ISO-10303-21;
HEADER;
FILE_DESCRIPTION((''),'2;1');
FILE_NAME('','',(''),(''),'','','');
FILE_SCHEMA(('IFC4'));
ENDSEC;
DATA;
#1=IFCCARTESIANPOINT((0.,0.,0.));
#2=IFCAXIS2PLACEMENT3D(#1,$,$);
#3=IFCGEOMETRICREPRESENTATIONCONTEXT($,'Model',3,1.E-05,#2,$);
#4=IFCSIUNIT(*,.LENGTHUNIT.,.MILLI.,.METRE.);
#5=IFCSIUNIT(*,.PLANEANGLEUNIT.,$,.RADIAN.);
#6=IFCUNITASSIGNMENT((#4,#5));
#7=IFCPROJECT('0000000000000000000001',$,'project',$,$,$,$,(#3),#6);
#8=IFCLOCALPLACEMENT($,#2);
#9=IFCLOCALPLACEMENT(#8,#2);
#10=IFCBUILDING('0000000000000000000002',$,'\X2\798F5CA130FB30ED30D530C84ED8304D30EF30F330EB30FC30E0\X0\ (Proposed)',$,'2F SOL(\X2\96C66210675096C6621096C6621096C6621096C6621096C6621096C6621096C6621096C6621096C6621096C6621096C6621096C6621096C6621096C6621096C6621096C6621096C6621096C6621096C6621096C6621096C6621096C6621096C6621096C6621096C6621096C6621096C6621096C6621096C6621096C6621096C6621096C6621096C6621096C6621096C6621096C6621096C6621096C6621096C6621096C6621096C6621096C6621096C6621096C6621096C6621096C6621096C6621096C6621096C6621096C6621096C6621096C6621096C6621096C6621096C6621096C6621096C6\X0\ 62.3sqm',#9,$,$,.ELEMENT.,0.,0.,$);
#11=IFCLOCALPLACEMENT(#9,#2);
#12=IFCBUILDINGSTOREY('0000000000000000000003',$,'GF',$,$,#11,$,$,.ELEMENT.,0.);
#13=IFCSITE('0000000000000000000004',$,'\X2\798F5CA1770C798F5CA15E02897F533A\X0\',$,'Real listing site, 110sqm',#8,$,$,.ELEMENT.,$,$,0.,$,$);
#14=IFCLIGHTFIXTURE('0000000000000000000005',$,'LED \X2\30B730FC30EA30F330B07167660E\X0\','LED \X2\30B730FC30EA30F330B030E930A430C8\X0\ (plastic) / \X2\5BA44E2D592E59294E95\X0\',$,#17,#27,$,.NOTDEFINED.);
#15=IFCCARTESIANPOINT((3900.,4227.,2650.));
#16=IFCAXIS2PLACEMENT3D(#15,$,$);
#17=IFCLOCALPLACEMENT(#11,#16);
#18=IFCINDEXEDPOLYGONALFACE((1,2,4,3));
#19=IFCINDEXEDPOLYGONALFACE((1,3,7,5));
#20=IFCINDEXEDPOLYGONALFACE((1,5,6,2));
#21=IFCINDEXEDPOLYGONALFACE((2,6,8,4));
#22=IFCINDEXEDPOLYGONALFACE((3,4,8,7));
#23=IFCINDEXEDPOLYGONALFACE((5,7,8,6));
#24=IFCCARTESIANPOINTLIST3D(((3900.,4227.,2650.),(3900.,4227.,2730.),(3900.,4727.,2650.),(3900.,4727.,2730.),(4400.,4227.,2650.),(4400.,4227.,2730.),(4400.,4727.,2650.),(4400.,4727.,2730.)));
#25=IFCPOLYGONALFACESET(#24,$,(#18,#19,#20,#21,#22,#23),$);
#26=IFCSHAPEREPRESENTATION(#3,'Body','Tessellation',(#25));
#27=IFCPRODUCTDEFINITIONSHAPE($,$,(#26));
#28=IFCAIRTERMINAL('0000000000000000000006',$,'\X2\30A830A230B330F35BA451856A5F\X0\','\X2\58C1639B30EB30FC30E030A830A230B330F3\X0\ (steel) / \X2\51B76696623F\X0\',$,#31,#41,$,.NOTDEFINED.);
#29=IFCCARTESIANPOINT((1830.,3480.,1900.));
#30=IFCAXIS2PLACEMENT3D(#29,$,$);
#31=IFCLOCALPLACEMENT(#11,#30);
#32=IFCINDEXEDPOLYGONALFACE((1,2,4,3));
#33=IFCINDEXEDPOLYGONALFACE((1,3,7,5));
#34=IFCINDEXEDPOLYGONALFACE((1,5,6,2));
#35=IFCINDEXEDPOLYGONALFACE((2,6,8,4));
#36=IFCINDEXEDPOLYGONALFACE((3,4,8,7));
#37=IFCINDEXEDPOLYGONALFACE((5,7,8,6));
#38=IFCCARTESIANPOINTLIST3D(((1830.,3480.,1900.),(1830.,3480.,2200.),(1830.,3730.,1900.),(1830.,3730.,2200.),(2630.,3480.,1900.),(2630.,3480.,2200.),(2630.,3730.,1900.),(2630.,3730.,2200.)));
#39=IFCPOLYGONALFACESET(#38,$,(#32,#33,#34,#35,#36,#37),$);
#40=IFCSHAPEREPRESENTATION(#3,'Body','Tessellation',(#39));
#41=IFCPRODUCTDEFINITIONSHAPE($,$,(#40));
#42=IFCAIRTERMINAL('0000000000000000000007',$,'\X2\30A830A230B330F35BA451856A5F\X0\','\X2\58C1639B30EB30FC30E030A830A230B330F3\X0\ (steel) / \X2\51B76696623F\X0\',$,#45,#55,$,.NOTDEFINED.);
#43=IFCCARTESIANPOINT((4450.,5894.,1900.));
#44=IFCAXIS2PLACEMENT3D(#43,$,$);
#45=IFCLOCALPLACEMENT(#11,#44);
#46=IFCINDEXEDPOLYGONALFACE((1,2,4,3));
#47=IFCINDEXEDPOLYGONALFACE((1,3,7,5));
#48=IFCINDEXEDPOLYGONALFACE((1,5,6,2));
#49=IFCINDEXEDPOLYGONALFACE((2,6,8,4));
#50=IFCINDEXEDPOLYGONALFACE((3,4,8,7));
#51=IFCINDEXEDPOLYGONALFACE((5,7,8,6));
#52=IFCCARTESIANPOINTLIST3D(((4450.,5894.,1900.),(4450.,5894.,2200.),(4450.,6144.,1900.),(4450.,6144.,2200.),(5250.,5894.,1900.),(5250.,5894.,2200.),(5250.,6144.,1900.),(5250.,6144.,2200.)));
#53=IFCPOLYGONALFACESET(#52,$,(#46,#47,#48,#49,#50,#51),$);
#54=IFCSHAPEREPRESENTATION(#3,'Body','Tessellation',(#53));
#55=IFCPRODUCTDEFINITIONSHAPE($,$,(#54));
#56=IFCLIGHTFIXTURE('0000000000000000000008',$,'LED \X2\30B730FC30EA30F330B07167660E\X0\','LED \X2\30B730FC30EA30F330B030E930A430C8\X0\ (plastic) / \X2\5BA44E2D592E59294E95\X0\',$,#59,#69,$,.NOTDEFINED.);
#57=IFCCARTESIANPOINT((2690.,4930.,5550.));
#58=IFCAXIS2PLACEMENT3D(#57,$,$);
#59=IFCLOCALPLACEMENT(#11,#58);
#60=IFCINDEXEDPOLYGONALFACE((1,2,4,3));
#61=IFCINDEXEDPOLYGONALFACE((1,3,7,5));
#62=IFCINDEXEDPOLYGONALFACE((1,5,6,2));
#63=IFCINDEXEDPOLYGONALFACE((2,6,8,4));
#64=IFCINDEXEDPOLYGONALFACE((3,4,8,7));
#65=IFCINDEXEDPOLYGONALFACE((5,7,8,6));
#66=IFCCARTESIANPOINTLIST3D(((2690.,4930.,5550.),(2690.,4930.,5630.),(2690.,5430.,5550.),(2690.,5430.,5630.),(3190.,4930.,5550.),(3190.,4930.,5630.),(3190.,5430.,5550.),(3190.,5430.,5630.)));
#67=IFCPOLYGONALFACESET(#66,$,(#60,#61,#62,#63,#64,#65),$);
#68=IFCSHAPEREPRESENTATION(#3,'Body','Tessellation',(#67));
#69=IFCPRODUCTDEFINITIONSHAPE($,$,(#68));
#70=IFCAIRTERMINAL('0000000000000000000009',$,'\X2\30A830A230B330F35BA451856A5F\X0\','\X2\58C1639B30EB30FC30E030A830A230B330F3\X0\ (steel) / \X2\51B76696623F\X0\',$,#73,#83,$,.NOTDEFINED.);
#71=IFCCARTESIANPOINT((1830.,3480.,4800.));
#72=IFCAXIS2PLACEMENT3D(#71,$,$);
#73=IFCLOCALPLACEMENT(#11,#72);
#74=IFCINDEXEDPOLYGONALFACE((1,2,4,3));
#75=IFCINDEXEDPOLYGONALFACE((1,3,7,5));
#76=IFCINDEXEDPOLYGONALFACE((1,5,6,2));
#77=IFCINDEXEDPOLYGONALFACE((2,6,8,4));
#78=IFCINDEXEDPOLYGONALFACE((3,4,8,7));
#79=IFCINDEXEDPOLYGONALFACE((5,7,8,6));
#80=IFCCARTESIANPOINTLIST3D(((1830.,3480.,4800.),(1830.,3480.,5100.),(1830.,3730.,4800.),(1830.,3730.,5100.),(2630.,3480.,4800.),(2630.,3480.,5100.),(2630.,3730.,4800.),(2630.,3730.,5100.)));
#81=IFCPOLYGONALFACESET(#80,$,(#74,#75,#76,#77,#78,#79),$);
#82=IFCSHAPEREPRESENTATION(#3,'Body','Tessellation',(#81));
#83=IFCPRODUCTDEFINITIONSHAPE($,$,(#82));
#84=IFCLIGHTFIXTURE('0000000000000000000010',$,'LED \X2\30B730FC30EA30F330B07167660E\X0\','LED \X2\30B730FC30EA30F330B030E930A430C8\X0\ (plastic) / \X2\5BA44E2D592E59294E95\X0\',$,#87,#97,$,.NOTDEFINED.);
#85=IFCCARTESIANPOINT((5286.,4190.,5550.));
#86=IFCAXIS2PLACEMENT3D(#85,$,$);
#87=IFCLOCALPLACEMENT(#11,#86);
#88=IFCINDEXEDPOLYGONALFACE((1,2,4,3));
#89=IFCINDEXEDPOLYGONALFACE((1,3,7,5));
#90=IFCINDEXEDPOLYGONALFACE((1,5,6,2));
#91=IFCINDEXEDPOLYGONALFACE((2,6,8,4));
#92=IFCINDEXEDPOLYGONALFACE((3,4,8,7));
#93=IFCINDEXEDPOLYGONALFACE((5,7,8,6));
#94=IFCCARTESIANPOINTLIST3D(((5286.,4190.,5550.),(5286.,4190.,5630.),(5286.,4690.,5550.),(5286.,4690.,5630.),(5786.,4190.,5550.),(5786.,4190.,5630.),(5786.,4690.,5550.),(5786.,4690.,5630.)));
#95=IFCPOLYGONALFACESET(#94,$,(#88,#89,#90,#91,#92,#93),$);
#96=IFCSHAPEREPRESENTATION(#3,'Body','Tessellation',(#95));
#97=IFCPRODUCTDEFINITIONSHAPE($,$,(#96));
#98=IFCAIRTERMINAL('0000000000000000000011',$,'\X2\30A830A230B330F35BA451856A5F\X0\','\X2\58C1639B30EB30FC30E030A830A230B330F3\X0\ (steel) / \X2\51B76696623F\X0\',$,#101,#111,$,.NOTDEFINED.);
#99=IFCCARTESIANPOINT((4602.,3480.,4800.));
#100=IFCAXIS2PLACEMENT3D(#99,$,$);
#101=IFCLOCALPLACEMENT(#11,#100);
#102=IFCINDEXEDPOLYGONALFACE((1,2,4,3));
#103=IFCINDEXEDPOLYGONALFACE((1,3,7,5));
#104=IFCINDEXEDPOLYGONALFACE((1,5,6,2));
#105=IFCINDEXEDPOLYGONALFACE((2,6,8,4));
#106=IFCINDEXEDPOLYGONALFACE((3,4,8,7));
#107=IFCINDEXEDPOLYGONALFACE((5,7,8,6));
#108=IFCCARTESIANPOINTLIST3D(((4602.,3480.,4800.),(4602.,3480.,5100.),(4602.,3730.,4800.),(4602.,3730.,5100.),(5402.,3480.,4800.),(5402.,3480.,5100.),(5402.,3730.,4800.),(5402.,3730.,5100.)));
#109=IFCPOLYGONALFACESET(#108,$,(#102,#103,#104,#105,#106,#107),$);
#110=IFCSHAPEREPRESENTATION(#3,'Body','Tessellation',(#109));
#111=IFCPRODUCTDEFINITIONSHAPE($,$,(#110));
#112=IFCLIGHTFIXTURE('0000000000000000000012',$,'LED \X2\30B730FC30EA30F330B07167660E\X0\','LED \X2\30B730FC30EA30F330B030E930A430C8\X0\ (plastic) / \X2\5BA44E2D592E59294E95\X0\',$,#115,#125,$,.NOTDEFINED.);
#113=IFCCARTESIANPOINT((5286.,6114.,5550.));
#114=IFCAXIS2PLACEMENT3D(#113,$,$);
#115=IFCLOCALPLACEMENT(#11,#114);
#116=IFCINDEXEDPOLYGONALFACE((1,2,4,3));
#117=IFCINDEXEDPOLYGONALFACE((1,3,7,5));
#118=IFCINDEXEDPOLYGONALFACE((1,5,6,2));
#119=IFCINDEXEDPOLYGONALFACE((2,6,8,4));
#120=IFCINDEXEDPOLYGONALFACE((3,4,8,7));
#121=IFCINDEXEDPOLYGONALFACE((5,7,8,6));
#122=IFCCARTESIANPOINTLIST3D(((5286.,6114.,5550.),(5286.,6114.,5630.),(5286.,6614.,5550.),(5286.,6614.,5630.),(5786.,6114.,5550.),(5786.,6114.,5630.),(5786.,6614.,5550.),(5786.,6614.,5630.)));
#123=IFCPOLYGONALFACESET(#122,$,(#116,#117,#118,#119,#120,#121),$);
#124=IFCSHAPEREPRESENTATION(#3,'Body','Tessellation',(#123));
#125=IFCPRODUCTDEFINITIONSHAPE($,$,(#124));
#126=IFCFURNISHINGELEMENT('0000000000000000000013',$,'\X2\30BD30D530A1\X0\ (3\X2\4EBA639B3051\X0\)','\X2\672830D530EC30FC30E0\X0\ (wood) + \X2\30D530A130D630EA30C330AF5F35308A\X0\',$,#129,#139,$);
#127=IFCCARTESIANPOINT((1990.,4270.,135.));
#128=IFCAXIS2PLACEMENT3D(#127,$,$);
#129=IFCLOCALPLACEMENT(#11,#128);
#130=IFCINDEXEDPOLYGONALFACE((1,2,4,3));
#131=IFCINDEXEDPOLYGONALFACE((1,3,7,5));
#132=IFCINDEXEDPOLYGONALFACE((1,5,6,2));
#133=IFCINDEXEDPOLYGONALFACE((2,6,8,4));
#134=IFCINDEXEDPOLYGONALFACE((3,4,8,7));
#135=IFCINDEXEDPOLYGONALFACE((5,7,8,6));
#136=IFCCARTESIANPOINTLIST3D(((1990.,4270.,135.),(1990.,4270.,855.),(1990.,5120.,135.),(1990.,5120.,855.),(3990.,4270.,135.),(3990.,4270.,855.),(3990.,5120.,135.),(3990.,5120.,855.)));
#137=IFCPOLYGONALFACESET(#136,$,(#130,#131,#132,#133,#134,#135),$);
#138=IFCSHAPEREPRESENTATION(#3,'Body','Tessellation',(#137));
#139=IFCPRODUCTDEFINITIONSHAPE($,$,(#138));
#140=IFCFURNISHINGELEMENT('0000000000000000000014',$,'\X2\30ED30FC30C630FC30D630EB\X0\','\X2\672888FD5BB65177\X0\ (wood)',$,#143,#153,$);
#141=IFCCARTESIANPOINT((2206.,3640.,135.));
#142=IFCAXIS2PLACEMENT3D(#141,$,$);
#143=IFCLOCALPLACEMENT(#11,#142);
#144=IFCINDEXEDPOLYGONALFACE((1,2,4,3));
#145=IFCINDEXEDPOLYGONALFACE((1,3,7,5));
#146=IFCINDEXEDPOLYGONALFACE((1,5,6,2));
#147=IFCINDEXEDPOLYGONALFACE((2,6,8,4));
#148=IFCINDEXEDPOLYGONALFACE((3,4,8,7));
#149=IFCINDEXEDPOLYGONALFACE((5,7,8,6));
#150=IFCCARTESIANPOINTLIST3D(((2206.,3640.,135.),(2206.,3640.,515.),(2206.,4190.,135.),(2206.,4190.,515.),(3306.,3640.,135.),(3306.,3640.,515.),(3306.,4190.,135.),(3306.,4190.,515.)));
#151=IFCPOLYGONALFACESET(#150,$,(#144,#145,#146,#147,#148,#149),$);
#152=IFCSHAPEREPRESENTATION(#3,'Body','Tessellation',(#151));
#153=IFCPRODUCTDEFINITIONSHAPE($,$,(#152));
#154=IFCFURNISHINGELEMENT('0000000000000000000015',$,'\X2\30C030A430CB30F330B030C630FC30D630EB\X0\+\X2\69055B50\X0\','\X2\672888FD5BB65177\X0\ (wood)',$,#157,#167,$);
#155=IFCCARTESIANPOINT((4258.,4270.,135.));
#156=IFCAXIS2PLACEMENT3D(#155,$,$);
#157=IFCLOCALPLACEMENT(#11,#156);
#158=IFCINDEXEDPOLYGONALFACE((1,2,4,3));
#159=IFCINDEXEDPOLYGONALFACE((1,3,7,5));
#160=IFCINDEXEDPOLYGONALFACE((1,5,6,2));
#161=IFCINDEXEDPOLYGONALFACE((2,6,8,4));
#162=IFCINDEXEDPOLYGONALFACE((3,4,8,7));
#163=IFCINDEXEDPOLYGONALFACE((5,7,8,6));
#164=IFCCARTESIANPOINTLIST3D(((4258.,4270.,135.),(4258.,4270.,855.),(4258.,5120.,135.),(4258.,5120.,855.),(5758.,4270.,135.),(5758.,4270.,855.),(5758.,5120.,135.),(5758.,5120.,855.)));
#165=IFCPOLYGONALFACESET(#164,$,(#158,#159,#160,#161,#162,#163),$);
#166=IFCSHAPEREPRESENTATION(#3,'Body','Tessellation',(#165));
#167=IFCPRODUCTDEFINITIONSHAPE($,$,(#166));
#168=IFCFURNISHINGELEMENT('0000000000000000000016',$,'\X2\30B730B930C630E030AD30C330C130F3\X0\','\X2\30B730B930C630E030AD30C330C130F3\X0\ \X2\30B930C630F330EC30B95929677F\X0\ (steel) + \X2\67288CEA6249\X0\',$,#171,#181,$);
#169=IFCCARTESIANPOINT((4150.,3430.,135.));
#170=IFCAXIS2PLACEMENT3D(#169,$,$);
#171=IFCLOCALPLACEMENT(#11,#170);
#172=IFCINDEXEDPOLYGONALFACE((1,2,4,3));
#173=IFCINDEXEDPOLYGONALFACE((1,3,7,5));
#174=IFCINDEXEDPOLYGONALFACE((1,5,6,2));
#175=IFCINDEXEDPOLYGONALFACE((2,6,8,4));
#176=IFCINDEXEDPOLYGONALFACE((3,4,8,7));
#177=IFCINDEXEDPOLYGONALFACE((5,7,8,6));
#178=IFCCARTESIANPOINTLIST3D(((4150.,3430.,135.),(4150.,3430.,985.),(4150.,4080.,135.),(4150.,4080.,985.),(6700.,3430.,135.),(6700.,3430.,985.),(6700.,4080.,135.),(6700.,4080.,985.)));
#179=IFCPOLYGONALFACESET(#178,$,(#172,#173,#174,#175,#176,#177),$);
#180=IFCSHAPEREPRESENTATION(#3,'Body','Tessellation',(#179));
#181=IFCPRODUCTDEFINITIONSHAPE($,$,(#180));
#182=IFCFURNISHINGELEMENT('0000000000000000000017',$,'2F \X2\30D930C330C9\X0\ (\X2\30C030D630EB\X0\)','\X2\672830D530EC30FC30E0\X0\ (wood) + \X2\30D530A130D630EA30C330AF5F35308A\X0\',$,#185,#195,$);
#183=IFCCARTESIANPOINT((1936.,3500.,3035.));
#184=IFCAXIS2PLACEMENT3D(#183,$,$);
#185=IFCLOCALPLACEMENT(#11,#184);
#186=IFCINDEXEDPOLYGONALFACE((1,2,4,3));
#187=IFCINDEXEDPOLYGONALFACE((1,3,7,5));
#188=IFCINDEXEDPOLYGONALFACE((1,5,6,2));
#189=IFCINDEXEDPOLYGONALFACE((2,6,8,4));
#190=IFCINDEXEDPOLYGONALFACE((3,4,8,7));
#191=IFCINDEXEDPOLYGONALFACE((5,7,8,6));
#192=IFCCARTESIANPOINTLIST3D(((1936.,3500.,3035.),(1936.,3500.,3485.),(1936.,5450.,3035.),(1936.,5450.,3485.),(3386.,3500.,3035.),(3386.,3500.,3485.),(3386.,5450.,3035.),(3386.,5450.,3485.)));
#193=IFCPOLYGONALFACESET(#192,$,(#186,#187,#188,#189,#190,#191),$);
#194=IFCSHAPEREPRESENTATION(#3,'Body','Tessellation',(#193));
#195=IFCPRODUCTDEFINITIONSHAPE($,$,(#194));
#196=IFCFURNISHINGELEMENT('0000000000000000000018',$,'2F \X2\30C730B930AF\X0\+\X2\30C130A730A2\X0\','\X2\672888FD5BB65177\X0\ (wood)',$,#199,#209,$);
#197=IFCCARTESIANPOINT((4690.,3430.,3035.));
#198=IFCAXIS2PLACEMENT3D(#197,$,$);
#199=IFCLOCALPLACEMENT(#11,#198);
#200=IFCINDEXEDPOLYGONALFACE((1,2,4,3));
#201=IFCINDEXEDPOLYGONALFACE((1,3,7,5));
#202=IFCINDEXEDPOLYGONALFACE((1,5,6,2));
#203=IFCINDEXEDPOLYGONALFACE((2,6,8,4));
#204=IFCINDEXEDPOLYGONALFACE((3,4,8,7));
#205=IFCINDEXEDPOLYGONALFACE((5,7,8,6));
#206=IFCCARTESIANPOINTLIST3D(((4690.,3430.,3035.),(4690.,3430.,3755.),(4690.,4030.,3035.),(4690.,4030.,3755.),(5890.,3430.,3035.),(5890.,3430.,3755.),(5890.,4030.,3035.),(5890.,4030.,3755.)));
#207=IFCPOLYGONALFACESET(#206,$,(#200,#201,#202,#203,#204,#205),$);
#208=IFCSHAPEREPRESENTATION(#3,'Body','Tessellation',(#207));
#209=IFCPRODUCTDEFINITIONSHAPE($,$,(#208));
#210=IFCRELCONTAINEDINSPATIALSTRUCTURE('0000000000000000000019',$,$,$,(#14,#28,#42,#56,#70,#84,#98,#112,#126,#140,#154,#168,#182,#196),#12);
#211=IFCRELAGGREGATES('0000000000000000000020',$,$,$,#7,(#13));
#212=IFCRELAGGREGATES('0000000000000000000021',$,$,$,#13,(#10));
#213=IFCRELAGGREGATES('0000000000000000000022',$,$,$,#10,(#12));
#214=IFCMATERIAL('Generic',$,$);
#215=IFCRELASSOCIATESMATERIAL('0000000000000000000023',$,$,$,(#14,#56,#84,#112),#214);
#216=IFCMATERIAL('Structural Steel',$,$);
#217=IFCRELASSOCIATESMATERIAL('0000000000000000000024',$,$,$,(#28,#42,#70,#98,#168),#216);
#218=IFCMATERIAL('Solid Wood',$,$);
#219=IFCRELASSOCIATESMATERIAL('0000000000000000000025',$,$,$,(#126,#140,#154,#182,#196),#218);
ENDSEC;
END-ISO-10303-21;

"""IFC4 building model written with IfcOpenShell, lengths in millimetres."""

from ifc_helpers import new_model, si_unit, frame, frame_2d, origin, place, context, project, spatial, rectangle, extrude, material, element, save


model = new_model("IFC4")

# Units and contexts
model_context = context("Model", 3, precision=1e-05, world=origin())
ifc_project = project(units=[si_unit("LENGTHUNIT", "METRE", prefix="MILLI"), si_unit("PLANEANGLEUNIT", "RADIAN")], contexts=[model_context])

# Site, building, storey
site_placement = place(None, origin())
site = spatial("IfcSite", under=ifc_project, at=site_placement, Name="福岡県福岡市西区", ObjectType="Real listing site, 110sqm", CompositionType="ELEMENT", RefElevation=0.0)
building_placement = place(site_placement, origin())
building = spatial("IfcBuilding", under=site, at=building_placement, Name="福岡・ロフト付きワンルーム (Proposed)", ObjectType="2F SOL(集成材集成集成集成集成集成集成集成集成集成集成集成集成集成集成集成集成集成集成集成集成集成集成集成集成集成集成集成集成集成集成集成集成集成集成集成集成集成集成集成集成集成集成集成集成集成集成集成集成集成集成集成集成集成集成集成集成集 62.3sqm", CompositionType="ELEMENT", ElevationOfRefHeight=0.0, ElevationOfTerrain=0.0)
storey_placement = place(building_placement, origin())
storey = spatial("IfcBuildingStorey", under=building, at=storey_placement, Name="GF", CompositionType="ELEMENT", Elevation=0.0)

# Shared definitions
ifc_material_1 = material(Name="Solid Wood")

# Shared definitions
ifc_material_2 = material(Name="Structural Steel")

# Shared definitions
ifc_material_3 = material(Name="Generic")

# Light fixture
light_fixture_1_placement = place(storey_placement, frame((3900.0, 4227.0, 2650.0)))
element("IfcLightFixture", 1, at=light_fixture_1_placement, inside=storey, material=ifc_material_3, Name="LED シーリング照明", Description="LED シーリングライト (plastic) / 室中央天井", PredefinedType="NOTDEFINED", context=model_context, shape_type="SweptSolid", body=[
    extrude(rectangle(XDim=500.0, YDim=500.0, at=frame_2d((250.0, 250.0))), frame((3900.0, 4227.0, 2650.0)), (0.0, 0.0, 1.0), 80.0),
])

# Air terminals
air_terminal_1_placement = place(storey_placement, frame((1830.0, 3480.0, 1900.0)))
element("IfcAirTerminal", 2, at=air_terminal_1_placement, inside=storey, material=ifc_material_2, Name="エアコン室内機", Description="壁掛ルームエアコン (steel) / 冷暖房", PredefinedType="NOTDEFINED", context=model_context, shape_type="SweptSolid", body=[
    extrude(rectangle(XDim=800.0, YDim=250.0, at=frame_2d((400.0, 125.0))), frame((1830.0, 3480.0, 1900.0)), (0.0, 0.0, 1.0), 300.0),
])
air_terminal_2_placement = place(storey_placement, frame((4450.0, 5894.0, 1900.0)))
element("IfcAirTerminal", 3, at=air_terminal_2_placement, inside=storey, material=ifc_material_2, Name="エアコン室内機", Description="壁掛ルームエアコン (steel) / 冷暖房", PredefinedType="NOTDEFINED", context=model_context, shape_type="SweptSolid", body=[
    extrude(rectangle(XDim=800.0, YDim=250.0, at=frame_2d((400.0, 125.0))), frame((4450.0, 5894.0, 1900.0)), (0.0, 0.0, 1.0), 300.0),
])

# Light fixture
light_fixture_2_placement = place(storey_placement, frame((2690.0, 4930.0, 5550.0)))
element("IfcLightFixture", 4, at=light_fixture_2_placement, inside=storey, material=ifc_material_3, Name="LED シーリング照明", Description="LED シーリングライト (plastic) / 室中央天井", PredefinedType="NOTDEFINED", context=model_context, shape_type="SweptSolid", body=[
    extrude(rectangle(XDim=500.0, YDim=500.0, at=frame_2d((250.0, 250.0))), frame((2690.0, 4930.0, 5550.0)), (0.0, 0.0, 1.0), 80.0),
])

# Air terminal
air_terminal_3_placement = place(storey_placement, frame((1830.0, 3480.0, 4800.0)))
element("IfcAirTerminal", 5, at=air_terminal_3_placement, inside=storey, material=ifc_material_2, Name="エアコン室内機", Description="壁掛ルームエアコン (steel) / 冷暖房", PredefinedType="NOTDEFINED", context=model_context, shape_type="SweptSolid", body=[
    extrude(rectangle(XDim=800.0, YDim=250.0, at=frame_2d((400.0, 125.0))), frame((1830.0, 3480.0, 4800.0)), (0.0, 0.0, 1.0), 300.0),
])

# Light fixture
light_fixture_3_placement = place(storey_placement, frame((5286.0, 4190.0, 5550.0)))
element("IfcLightFixture", 6, at=light_fixture_3_placement, inside=storey, material=ifc_material_3, Name="LED シーリング照明", Description="LED シーリングライト (plastic) / 室中央天井", PredefinedType="NOTDEFINED", context=model_context, shape_type="SweptSolid", body=[
    extrude(rectangle(XDim=500.0, YDim=500.0, at=frame_2d((250.0, 250.0))), frame((5286.0, 4190.0, 5550.0)), (0.0, 0.0, 1.0), 80.0),
])

# Air terminal
air_terminal_4_placement = place(storey_placement, frame((4602.0, 3480.0, 4800.0)))
element("IfcAirTerminal", 7, at=air_terminal_4_placement, inside=storey, material=ifc_material_2, Name="エアコン室内機", Description="壁掛ルームエアコン (steel) / 冷暖房", PredefinedType="NOTDEFINED", context=model_context, shape_type="SweptSolid", body=[
    extrude(rectangle(XDim=800.0, YDim=250.0, at=frame_2d((400.0, 125.0))), frame((4602.0, 3480.0, 4800.0)), (0.0, 0.0, 1.0), 300.0),
])

# Light fixture
light_fixture_4_placement = place(storey_placement, frame((5286.0, 6114.0, 5550.0)))
element("IfcLightFixture", 8, at=light_fixture_4_placement, inside=storey, material=ifc_material_3, Name="LED シーリング照明", Description="LED シーリングライト (plastic) / 室中央天井", PredefinedType="NOTDEFINED", context=model_context, shape_type="SweptSolid", body=[
    extrude(rectangle(XDim=500.0, YDim=500.0, at=frame_2d((250.0, 250.0))), frame((5286.0, 6114.0, 5550.0)), (0.0, 0.0, 1.0), 80.0),
])

# Furnishing elements
furnishing_1_placement = place(storey_placement, frame((1990.0, 4270.0, 135.0)))
element("IfcFurnishingElement", 9, at=furnishing_1_placement, inside=storey, material=ifc_material_1, Name="ソファ (3人掛け)", Description="木フレーム (wood) + ファブリック張り", context=model_context, shape_type="SweptSolid", body=[
    extrude(rectangle(XDim=2000.0, YDim=850.0, at=frame_2d((1000.0, 425.0))), frame((1990.0, 4270.0, 135.0)), (0.0, 0.0, 1.0), 720.0),
])
furnishing_2_placement = place(storey_placement, frame((2206.0, 3640.0, 135.0)))
element("IfcFurnishingElement", 10, at=furnishing_2_placement, inside=storey, material=ifc_material_1, Name="ローテーブル", Description="木製家具 (wood)", context=model_context, shape_type="SweptSolid", body=[
    extrude(rectangle(XDim=1100.0, YDim=550.0, at=frame_2d((550.0, 275.0))), frame((2206.0, 3640.0, 135.0)), (0.0, 0.0, 1.0), 380.0),
])
furnishing_3_placement = place(storey_placement, frame((4258.0, 4270.0, 135.0)))
element("IfcFurnishingElement", 11, at=furnishing_3_placement, inside=storey, material=ifc_material_1, Name="ダイニングテーブル+椅子", Description="木製家具 (wood)", context=model_context, shape_type="SweptSolid", body=[
    extrude(rectangle(XDim=1500.0, YDim=850.0, at=frame_2d((750.0, 425.0))), frame((4258.0, 4270.0, 135.0)), (0.0, 0.0, 1.0), 720.0),
])
furnishing_4_placement = place(storey_placement, frame((4150.0, 3430.0, 135.0)))
element("IfcFurnishingElement", 12, at=furnishing_4_placement, inside=storey, material=ifc_material_2, Name="システムキッチン", Description="システムキッチン ステンレス天板 (steel) + 木質扉", context=model_context, shape_type="SweptSolid", body=[
    extrude(rectangle(XDim=2550.0, YDim=650.0, at=frame_2d((1275.0, 325.0))), frame((4150.0, 3430.0, 135.0)), (0.0, 0.0, 1.0), 850.0),
])
furnishing_5_placement = place(storey_placement, frame((1936.0, 3500.0, 3035.0)))
element("IfcFurnishingElement", 13, at=furnishing_5_placement, inside=storey, material=ifc_material_1, Name="2F ベッド (ダブル)", Description="木フレーム (wood) + ファブリック張り", context=model_context, shape_type="SweptSolid", body=[
    extrude(rectangle(XDim=1450.0, YDim=1950.0, at=frame_2d((725.0, 975.0))), frame((1936.0, 3500.0, 3035.0)), (0.0, 0.0, 1.0), 450.0),
])
furnishing_6_placement = place(storey_placement, frame((4690.0, 3430.0, 3035.0)))
element("IfcFurnishingElement", 14, at=furnishing_6_placement, inside=storey, material=ifc_material_1, Name="2F デスク+チェア", Description="木製家具 (wood)", context=model_context, shape_type="SweptSolid", body=[
    extrude(rectangle(XDim=1200.0, YDim=600.0, at=frame_2d((600.0, 300.0))), frame((4690.0, 3430.0, 3035.0)), (0.0, 0.0, 1.0), 720.0),
])

save(model, "model.ifc")
